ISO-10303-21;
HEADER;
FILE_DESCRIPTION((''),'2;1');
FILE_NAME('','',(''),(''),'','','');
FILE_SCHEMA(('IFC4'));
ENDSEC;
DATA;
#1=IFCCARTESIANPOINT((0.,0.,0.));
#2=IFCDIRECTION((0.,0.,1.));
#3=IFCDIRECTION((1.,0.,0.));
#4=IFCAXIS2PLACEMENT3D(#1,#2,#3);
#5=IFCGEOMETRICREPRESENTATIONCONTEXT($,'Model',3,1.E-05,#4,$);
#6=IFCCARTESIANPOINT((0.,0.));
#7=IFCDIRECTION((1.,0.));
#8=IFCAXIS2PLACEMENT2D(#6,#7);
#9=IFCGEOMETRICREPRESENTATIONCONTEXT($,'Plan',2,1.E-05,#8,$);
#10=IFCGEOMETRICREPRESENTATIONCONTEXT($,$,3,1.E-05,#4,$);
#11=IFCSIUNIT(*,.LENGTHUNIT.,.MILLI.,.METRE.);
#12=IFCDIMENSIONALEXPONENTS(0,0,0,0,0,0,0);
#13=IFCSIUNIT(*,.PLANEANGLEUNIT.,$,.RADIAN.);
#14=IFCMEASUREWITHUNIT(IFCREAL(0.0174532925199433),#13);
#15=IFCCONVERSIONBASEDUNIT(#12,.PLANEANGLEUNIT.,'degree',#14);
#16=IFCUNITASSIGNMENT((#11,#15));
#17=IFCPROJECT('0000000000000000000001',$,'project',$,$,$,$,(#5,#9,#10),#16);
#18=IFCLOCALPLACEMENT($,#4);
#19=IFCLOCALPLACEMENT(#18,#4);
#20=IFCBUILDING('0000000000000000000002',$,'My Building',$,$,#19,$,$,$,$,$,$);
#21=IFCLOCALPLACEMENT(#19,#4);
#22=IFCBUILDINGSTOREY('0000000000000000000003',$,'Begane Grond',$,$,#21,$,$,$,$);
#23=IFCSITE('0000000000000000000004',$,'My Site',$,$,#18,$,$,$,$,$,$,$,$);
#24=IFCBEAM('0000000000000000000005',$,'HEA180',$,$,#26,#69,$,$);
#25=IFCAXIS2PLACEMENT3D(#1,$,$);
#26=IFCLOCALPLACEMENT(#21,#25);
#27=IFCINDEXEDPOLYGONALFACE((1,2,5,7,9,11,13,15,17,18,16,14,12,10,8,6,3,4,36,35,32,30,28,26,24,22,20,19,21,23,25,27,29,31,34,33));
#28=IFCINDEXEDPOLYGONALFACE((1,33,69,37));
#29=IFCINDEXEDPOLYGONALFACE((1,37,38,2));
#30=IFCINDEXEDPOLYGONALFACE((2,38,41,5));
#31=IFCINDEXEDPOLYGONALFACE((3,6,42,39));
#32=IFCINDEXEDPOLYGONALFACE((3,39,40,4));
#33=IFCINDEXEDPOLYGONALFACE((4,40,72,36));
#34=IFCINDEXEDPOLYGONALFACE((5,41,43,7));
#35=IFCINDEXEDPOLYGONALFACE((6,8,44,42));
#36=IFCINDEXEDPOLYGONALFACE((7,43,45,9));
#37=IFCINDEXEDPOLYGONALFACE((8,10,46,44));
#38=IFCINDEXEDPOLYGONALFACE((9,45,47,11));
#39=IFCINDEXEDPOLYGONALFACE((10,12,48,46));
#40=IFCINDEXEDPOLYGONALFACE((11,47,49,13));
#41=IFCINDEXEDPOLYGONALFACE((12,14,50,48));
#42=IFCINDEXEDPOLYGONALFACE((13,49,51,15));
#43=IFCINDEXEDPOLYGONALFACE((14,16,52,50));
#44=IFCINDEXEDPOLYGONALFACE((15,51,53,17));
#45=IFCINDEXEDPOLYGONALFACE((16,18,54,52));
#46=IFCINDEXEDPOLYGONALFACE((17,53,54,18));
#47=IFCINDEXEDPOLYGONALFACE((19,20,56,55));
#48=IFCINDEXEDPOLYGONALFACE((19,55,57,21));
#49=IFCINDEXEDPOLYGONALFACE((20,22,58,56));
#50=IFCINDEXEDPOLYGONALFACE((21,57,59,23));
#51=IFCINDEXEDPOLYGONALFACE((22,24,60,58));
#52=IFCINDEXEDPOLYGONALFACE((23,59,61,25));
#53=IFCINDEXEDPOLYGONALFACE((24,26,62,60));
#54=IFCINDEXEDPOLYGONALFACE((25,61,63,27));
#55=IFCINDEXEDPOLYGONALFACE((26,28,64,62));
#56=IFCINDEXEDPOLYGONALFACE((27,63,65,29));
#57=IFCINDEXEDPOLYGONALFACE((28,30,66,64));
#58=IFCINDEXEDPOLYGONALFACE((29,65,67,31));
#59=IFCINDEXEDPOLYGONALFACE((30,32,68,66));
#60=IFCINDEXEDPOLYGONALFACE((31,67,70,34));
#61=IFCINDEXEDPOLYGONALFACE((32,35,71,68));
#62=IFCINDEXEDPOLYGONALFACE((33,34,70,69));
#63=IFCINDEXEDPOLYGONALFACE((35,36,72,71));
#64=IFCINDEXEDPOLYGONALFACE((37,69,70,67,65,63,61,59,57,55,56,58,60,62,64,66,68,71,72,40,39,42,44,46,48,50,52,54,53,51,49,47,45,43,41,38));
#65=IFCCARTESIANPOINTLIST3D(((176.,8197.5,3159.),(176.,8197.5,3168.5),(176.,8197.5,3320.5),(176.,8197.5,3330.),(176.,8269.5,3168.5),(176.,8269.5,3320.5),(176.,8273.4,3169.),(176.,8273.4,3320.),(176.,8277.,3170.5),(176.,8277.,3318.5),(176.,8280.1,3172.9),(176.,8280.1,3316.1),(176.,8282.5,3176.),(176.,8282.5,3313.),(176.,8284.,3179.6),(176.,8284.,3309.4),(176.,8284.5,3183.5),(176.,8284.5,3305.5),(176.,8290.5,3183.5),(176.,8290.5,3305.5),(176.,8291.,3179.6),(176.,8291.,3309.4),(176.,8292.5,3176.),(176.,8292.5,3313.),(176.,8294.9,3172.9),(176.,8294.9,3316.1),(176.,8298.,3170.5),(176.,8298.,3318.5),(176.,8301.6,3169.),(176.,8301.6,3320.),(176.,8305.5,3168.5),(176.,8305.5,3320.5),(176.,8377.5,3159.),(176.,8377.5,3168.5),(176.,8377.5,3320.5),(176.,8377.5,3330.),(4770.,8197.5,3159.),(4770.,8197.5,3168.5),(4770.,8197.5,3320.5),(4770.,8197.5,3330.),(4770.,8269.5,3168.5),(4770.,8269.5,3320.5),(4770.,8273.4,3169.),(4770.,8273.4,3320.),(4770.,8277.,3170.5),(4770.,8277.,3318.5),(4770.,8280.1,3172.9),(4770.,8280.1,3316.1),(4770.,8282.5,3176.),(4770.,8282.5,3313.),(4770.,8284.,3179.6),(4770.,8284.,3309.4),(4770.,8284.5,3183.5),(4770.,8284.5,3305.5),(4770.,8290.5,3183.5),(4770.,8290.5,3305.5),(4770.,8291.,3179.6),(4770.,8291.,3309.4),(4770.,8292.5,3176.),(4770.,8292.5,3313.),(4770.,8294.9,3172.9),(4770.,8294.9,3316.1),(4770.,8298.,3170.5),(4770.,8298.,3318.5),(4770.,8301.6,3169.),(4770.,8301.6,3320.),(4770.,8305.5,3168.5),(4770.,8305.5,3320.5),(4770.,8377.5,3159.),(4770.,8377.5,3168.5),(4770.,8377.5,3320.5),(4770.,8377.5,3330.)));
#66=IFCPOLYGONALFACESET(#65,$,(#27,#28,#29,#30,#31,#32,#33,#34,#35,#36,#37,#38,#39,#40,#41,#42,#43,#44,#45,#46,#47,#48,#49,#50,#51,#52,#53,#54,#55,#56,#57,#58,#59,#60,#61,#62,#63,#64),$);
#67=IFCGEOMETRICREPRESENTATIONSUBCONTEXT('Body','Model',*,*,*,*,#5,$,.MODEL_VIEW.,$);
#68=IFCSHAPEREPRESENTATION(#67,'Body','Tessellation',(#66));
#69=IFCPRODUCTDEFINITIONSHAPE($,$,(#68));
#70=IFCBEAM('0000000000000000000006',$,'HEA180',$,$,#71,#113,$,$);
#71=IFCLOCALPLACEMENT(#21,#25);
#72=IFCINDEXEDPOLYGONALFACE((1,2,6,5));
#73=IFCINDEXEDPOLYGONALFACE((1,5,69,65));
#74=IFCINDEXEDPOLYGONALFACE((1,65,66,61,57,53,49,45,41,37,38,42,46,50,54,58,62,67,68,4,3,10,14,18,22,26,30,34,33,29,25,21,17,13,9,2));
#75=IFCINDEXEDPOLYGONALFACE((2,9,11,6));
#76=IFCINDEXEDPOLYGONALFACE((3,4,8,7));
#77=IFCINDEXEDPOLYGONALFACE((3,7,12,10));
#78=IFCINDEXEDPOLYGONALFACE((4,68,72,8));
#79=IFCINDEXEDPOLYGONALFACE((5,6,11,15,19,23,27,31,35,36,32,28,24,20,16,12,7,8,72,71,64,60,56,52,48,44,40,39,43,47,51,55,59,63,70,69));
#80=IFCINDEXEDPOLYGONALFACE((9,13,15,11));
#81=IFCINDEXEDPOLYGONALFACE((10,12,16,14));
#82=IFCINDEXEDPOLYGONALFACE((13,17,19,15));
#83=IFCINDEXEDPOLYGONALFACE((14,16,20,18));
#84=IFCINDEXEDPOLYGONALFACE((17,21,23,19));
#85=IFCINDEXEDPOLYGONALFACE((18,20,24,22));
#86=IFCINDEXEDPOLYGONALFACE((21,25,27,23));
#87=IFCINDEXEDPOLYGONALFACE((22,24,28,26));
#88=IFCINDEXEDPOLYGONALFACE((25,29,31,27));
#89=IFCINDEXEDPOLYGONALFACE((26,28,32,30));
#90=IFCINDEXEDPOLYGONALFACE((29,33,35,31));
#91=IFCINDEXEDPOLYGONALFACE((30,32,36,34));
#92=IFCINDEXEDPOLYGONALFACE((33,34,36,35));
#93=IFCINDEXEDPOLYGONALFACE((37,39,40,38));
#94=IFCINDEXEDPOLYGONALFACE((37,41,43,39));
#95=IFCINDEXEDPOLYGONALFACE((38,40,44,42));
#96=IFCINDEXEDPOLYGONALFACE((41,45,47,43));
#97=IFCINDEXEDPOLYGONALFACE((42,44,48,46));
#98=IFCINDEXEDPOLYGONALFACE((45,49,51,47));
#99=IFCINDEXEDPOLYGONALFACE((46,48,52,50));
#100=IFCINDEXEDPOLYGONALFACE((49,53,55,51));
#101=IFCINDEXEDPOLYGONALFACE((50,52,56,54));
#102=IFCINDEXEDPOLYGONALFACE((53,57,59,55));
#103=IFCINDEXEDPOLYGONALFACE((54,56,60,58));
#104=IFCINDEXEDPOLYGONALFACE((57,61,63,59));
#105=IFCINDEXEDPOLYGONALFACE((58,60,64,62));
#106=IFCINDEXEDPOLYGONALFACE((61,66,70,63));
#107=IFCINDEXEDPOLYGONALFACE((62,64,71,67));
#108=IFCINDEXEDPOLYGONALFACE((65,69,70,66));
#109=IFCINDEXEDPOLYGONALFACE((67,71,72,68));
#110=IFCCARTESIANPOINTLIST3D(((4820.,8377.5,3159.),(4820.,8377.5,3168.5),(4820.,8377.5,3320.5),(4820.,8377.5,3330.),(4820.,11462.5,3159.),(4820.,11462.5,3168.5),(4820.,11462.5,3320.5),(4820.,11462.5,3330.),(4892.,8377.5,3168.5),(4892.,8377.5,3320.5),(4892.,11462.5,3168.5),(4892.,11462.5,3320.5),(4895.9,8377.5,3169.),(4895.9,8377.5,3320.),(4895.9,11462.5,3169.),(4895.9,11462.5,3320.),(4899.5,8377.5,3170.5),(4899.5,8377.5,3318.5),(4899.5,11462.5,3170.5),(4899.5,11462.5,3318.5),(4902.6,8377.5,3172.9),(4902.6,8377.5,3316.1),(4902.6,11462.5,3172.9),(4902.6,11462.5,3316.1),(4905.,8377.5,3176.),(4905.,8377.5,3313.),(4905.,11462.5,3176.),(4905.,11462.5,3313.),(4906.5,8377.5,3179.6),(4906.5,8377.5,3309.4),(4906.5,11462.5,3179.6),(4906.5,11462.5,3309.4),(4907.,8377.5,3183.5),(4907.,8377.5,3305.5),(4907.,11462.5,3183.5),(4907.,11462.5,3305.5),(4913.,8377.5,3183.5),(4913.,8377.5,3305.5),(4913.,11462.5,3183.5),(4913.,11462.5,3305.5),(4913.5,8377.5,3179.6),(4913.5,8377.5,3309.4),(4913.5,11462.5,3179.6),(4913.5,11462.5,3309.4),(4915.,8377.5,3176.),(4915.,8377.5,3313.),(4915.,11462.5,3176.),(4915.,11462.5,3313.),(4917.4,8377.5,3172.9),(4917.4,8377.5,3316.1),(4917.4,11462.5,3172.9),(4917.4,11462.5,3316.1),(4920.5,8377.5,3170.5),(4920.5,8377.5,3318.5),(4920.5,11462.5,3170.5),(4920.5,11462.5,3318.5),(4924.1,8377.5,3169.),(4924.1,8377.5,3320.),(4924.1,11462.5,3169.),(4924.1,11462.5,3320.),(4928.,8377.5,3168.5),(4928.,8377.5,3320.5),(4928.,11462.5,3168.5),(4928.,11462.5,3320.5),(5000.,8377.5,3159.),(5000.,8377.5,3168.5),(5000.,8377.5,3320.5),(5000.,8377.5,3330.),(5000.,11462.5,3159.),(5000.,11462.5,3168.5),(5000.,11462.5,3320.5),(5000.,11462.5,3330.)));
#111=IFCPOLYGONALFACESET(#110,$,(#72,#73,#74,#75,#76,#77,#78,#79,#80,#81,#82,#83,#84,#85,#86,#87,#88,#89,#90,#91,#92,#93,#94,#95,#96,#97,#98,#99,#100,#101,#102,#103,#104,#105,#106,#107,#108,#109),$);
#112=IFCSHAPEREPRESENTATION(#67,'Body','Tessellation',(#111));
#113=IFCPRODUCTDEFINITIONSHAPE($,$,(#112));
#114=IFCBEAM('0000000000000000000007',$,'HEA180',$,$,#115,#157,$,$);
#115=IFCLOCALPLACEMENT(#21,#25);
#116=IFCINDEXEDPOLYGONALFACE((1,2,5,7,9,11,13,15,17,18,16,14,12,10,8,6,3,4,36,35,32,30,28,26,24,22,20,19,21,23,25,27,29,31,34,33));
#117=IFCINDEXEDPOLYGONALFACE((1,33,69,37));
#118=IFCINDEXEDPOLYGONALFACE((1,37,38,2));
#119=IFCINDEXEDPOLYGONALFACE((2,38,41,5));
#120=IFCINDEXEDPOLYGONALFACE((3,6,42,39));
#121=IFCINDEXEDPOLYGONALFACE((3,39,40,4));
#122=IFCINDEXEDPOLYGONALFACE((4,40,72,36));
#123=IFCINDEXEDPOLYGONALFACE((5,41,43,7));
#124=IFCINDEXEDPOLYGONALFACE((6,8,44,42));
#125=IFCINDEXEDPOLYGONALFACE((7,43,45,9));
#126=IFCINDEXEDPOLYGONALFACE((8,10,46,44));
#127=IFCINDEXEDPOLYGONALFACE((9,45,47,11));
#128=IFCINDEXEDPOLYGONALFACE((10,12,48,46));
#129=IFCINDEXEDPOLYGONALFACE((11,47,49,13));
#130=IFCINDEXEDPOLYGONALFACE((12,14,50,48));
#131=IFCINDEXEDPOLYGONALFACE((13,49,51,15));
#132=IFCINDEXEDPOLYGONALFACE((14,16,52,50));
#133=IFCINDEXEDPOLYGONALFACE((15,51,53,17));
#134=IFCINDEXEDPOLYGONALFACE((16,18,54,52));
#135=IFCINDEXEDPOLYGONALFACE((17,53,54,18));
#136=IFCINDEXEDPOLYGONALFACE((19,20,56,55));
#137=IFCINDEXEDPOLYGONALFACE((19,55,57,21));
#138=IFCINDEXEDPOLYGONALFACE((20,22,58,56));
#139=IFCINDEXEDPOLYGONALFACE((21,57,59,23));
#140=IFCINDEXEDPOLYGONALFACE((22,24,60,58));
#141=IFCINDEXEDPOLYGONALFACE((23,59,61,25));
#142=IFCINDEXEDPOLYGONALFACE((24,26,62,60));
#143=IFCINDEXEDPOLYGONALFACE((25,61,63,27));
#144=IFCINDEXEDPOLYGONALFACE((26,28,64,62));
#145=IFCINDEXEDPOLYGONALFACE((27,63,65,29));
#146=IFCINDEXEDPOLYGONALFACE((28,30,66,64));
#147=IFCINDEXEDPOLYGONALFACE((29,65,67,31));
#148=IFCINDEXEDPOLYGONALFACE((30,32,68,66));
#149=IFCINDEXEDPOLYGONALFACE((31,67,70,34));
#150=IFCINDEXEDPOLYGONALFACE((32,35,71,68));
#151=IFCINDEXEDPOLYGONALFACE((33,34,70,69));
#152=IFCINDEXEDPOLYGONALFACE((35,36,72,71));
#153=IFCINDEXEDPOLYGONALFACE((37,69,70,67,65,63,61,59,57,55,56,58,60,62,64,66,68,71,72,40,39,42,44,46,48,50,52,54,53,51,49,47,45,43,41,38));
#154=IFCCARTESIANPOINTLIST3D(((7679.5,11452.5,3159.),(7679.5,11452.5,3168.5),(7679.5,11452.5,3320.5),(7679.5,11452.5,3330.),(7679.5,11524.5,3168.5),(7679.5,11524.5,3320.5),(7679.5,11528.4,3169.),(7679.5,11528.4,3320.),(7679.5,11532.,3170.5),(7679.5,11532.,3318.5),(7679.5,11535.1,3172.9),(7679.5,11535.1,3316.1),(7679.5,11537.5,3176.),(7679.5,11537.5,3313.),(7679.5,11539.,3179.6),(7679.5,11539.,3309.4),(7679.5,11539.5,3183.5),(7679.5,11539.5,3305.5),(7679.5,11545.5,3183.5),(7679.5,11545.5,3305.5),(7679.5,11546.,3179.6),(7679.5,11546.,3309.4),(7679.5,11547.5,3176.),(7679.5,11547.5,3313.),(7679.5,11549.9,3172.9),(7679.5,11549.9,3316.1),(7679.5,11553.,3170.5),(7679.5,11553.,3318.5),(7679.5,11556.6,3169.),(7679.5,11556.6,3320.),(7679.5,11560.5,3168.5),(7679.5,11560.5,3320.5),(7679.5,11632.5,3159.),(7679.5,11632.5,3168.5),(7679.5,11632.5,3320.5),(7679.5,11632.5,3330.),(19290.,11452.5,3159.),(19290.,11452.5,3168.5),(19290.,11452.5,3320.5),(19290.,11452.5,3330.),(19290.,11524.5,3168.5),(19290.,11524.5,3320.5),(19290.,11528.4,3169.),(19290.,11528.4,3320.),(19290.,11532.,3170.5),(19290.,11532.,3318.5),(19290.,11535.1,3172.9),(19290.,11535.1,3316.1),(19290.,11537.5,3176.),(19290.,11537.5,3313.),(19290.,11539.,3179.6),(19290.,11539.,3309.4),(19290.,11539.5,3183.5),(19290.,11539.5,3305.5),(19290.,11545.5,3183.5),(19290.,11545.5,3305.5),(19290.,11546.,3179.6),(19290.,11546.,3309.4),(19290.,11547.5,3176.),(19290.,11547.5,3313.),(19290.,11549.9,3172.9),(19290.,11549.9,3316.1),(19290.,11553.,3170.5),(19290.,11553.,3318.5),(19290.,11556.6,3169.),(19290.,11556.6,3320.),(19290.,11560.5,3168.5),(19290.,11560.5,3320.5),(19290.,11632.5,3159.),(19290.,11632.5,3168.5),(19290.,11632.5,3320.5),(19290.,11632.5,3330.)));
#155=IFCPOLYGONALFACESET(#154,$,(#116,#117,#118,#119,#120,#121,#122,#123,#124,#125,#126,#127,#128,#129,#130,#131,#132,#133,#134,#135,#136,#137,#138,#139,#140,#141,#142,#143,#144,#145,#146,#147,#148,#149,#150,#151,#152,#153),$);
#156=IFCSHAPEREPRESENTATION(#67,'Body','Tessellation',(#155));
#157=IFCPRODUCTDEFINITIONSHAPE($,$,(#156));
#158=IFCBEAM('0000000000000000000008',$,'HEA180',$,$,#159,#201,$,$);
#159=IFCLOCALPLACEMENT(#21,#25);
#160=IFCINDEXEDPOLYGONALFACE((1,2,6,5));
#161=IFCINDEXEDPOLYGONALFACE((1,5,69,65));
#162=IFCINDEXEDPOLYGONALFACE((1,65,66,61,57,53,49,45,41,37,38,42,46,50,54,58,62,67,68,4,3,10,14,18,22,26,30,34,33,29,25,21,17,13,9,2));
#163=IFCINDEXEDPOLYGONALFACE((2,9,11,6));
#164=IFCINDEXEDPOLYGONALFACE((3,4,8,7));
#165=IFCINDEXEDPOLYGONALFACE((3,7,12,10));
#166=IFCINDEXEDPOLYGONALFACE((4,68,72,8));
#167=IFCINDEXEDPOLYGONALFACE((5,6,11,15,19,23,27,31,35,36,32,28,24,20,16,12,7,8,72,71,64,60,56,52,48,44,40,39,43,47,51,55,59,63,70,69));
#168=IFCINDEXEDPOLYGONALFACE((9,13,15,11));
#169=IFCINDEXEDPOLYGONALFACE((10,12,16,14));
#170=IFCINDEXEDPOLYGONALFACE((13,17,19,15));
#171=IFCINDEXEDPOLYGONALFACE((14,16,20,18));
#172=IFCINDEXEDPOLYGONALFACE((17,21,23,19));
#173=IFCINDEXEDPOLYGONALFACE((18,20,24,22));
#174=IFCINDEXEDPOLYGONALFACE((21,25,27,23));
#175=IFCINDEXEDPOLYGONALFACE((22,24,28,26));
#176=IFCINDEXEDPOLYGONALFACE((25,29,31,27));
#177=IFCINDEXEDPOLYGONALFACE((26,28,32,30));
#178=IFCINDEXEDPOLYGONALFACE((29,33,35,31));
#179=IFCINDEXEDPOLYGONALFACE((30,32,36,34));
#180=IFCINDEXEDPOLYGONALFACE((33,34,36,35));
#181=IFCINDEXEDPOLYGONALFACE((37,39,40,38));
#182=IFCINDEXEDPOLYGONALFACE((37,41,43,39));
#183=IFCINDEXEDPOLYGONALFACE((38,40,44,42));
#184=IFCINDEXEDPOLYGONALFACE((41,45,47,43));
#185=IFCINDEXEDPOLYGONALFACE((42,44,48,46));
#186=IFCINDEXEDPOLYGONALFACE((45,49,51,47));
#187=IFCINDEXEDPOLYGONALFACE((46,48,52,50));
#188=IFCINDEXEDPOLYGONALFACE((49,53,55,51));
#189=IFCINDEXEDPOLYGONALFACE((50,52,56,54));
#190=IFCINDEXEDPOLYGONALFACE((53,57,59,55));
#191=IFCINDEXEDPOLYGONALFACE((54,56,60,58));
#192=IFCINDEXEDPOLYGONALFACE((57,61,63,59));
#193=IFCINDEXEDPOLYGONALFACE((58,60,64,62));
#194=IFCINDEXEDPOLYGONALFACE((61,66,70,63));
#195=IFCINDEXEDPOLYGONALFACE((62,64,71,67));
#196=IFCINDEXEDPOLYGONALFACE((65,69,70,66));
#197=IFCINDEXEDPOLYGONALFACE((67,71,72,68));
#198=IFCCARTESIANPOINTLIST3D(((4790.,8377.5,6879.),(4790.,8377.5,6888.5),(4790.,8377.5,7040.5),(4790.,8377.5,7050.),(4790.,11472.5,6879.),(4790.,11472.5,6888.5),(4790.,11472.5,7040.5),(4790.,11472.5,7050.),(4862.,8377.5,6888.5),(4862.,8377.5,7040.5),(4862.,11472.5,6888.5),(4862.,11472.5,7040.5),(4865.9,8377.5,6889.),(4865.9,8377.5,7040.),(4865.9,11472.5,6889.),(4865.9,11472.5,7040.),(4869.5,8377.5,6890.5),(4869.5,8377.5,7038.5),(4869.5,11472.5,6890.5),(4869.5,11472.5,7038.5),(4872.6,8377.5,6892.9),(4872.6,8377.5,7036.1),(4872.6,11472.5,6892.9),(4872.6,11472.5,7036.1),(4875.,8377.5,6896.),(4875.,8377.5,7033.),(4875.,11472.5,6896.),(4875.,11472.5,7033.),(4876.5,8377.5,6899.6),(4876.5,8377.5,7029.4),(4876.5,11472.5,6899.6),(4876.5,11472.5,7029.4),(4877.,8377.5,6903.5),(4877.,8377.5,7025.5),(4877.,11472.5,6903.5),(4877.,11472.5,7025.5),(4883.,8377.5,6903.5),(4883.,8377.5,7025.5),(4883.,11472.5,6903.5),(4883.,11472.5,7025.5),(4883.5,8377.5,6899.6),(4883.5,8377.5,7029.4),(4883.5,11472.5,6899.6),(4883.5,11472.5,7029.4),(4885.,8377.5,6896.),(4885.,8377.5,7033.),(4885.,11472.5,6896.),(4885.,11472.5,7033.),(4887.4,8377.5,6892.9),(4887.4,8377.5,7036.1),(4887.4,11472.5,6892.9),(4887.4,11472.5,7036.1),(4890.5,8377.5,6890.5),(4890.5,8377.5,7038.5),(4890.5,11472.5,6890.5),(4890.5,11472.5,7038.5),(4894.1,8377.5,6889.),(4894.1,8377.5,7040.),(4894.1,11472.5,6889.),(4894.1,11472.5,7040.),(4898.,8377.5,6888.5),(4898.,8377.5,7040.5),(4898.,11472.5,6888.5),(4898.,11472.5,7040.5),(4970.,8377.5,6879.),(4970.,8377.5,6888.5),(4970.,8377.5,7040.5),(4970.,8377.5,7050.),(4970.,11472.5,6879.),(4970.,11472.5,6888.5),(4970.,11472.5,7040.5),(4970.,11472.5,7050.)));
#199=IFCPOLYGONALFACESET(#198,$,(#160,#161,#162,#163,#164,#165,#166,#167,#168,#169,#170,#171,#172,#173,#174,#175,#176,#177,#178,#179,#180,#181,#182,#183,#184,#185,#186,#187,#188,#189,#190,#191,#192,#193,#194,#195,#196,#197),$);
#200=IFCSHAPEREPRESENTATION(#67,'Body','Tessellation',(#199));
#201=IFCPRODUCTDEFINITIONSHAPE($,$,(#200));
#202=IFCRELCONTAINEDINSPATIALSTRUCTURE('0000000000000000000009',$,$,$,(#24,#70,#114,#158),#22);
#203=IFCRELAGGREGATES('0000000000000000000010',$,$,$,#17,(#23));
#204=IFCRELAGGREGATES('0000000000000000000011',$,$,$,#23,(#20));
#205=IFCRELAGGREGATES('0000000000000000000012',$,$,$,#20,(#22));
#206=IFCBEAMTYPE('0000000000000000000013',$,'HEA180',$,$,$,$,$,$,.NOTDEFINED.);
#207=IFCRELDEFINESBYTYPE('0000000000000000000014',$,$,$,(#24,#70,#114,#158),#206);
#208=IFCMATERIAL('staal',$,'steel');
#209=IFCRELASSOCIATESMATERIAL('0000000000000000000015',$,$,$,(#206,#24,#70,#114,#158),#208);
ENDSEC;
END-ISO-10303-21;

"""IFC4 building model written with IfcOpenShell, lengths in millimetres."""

from ifc_helpers import new_model, entity, si_unit, converted_unit, frame, origin_with_axes, origin_2d_with_axis, place, context, subcontext, project, spatial, i_section, extrude, material, material_profile, profile_set, profile_usage, type_object, element, save


model = new_model("IFC4")

# Units and contexts
model_context = context("Model", 3, precision=1e-05, world=origin_with_axes())
plan_context = context("Plan", 2, precision=1e-05, world=origin_2d_with_axis())
context_of_model = context(None, 3, precision=1e-05, world=origin_with_axes())
body_context = subcontext(model_context, "Body", "Model", "MODEL_VIEW")
ifc_project = project(units=[si_unit("LENGTHUNIT", "METRE", prefix="MILLI"), converted_unit("PLANEANGLEUNIT", "degree", entity("IfcReal", 0.0174532925199433), si_unit("PLANEANGLEUNIT", "RADIAN"), dimensions=[0, 0, 0, 0, 0, 0, 0])], contexts=[model_context, plan_context, context_of_model])

# Site, building, storey
site_placement = place(None, origin_with_axes())
site = spatial("IfcSite", under=ifc_project, at=site_placement, Name="My Site")
building_placement = place(site_placement, origin_with_axes())
building = spatial("IfcBuilding", under=site, at=building_placement, Name="My Building")
storey_placement = place(building_placement, origin_with_axes())
storey = spatial("IfcBuildingStorey", under=building, at=storey_placement, Name="Begane Grond")

# Shared definitions
ifc_material = material(Name="staal", Category="steel")

# Beams
ifc_material_profile_1 = material_profile(ifc_material, i_section(OverallWidth=180.0, OverallDepth=171.0, WebThickness=6.0, FlangeThickness=9.5, FilletRadius=15.0))
ifc_profile_set_1 = profile_set([ifc_material_profile_1], Name="HEA180")
beam_type_1 = type_object("IfcBeamType", Name="HEA180", PredefinedType="NOTDEFINED", material=ifc_profile_set_1)
ifc_profile_usage_1 = profile_usage(ifc_profile_set_1)
beam_1_placement = place(storey_placement, frame((176.0, 8287.5, 3244.5), z_axis=(1.0, 0.0, 0.0), x_axis=(0.0, 1.0, 0.0)))
element("IfcBeam", 1, at=beam_1_placement, inside=storey, type_object=beam_type_1, material=ifc_profile_usage_1, Name="HEA180", context=body_context, shape_type="SweptSolid", body=[
    extrude(i_section(OverallWidth=180.0, OverallDepth=171.0, WebThickness=6.0, FlangeThickness=9.5, FilletRadius=15.0), origin_with_axes(), (0.0, 0.0, 1.0), 4594.0),
])
ifc_profile_usage_2 = profile_usage(ifc_profile_set_1)
beam_2_placement = place(storey_placement, frame((4910.0, 8377.5, 3244.5), z_axis=(0.0, 1.0, 0.0), x_axis=(-1.0, 0.0, 0.0)))
element("IfcBeam", 2, at=beam_2_placement, inside=storey, type_object=beam_type_1, material=ifc_profile_usage_2, Name="HEA180", context=body_context, shape_type="SweptSolid", body=[
    extrude(i_section(OverallWidth=180.0, OverallDepth=171.0, WebThickness=6.0, FlangeThickness=9.5, FilletRadius=15.0), origin_with_axes(), (0.0, 0.0, 1.0), 3085.0),
])
ifc_profile_usage_3 = profile_usage(ifc_profile_set_1)
beam_3_placement = place(storey_placement, frame((7679.5, 11542.5, 3244.5), z_axis=(1.0, 0.0, 0.0), x_axis=(0.0, 1.0, 0.0)))
element("IfcBeam", 3, at=beam_3_placement, inside=storey, type_object=beam_type_1, material=ifc_profile_usage_3, Name="HEA180", context=body_context, shape_type="SweptSolid", body=[
    extrude(i_section(OverallWidth=180.0, OverallDepth=171.0, WebThickness=6.0, FlangeThickness=9.5, FilletRadius=15.0), origin_with_axes(), (0.0, 0.0, 1.0), 11610.5),
])
ifc_profile_usage_4 = profile_usage(ifc_profile_set_1)
beam_4_placement = place(storey_placement, frame((4880.0, 11472.5, 6964.5), z_axis=(0.0, -1.0, 0.0), x_axis=(1.0, 0.0, 0.0)))
element("IfcBeam", 4, at=beam_4_placement, inside=storey, type_object=beam_type_1, material=ifc_profile_usage_4, Name="HEA180", context=body_context, shape_type="SweptSolid", body=[
    extrude(i_section(OverallWidth=180.0, OverallDepth=171.0, WebThickness=6.0, FlangeThickness=9.5, FilletRadius=15.0), origin_with_axes(), (0.0, 0.0, 1.0), 3095.0),
])

save(model, "model.ifc")
